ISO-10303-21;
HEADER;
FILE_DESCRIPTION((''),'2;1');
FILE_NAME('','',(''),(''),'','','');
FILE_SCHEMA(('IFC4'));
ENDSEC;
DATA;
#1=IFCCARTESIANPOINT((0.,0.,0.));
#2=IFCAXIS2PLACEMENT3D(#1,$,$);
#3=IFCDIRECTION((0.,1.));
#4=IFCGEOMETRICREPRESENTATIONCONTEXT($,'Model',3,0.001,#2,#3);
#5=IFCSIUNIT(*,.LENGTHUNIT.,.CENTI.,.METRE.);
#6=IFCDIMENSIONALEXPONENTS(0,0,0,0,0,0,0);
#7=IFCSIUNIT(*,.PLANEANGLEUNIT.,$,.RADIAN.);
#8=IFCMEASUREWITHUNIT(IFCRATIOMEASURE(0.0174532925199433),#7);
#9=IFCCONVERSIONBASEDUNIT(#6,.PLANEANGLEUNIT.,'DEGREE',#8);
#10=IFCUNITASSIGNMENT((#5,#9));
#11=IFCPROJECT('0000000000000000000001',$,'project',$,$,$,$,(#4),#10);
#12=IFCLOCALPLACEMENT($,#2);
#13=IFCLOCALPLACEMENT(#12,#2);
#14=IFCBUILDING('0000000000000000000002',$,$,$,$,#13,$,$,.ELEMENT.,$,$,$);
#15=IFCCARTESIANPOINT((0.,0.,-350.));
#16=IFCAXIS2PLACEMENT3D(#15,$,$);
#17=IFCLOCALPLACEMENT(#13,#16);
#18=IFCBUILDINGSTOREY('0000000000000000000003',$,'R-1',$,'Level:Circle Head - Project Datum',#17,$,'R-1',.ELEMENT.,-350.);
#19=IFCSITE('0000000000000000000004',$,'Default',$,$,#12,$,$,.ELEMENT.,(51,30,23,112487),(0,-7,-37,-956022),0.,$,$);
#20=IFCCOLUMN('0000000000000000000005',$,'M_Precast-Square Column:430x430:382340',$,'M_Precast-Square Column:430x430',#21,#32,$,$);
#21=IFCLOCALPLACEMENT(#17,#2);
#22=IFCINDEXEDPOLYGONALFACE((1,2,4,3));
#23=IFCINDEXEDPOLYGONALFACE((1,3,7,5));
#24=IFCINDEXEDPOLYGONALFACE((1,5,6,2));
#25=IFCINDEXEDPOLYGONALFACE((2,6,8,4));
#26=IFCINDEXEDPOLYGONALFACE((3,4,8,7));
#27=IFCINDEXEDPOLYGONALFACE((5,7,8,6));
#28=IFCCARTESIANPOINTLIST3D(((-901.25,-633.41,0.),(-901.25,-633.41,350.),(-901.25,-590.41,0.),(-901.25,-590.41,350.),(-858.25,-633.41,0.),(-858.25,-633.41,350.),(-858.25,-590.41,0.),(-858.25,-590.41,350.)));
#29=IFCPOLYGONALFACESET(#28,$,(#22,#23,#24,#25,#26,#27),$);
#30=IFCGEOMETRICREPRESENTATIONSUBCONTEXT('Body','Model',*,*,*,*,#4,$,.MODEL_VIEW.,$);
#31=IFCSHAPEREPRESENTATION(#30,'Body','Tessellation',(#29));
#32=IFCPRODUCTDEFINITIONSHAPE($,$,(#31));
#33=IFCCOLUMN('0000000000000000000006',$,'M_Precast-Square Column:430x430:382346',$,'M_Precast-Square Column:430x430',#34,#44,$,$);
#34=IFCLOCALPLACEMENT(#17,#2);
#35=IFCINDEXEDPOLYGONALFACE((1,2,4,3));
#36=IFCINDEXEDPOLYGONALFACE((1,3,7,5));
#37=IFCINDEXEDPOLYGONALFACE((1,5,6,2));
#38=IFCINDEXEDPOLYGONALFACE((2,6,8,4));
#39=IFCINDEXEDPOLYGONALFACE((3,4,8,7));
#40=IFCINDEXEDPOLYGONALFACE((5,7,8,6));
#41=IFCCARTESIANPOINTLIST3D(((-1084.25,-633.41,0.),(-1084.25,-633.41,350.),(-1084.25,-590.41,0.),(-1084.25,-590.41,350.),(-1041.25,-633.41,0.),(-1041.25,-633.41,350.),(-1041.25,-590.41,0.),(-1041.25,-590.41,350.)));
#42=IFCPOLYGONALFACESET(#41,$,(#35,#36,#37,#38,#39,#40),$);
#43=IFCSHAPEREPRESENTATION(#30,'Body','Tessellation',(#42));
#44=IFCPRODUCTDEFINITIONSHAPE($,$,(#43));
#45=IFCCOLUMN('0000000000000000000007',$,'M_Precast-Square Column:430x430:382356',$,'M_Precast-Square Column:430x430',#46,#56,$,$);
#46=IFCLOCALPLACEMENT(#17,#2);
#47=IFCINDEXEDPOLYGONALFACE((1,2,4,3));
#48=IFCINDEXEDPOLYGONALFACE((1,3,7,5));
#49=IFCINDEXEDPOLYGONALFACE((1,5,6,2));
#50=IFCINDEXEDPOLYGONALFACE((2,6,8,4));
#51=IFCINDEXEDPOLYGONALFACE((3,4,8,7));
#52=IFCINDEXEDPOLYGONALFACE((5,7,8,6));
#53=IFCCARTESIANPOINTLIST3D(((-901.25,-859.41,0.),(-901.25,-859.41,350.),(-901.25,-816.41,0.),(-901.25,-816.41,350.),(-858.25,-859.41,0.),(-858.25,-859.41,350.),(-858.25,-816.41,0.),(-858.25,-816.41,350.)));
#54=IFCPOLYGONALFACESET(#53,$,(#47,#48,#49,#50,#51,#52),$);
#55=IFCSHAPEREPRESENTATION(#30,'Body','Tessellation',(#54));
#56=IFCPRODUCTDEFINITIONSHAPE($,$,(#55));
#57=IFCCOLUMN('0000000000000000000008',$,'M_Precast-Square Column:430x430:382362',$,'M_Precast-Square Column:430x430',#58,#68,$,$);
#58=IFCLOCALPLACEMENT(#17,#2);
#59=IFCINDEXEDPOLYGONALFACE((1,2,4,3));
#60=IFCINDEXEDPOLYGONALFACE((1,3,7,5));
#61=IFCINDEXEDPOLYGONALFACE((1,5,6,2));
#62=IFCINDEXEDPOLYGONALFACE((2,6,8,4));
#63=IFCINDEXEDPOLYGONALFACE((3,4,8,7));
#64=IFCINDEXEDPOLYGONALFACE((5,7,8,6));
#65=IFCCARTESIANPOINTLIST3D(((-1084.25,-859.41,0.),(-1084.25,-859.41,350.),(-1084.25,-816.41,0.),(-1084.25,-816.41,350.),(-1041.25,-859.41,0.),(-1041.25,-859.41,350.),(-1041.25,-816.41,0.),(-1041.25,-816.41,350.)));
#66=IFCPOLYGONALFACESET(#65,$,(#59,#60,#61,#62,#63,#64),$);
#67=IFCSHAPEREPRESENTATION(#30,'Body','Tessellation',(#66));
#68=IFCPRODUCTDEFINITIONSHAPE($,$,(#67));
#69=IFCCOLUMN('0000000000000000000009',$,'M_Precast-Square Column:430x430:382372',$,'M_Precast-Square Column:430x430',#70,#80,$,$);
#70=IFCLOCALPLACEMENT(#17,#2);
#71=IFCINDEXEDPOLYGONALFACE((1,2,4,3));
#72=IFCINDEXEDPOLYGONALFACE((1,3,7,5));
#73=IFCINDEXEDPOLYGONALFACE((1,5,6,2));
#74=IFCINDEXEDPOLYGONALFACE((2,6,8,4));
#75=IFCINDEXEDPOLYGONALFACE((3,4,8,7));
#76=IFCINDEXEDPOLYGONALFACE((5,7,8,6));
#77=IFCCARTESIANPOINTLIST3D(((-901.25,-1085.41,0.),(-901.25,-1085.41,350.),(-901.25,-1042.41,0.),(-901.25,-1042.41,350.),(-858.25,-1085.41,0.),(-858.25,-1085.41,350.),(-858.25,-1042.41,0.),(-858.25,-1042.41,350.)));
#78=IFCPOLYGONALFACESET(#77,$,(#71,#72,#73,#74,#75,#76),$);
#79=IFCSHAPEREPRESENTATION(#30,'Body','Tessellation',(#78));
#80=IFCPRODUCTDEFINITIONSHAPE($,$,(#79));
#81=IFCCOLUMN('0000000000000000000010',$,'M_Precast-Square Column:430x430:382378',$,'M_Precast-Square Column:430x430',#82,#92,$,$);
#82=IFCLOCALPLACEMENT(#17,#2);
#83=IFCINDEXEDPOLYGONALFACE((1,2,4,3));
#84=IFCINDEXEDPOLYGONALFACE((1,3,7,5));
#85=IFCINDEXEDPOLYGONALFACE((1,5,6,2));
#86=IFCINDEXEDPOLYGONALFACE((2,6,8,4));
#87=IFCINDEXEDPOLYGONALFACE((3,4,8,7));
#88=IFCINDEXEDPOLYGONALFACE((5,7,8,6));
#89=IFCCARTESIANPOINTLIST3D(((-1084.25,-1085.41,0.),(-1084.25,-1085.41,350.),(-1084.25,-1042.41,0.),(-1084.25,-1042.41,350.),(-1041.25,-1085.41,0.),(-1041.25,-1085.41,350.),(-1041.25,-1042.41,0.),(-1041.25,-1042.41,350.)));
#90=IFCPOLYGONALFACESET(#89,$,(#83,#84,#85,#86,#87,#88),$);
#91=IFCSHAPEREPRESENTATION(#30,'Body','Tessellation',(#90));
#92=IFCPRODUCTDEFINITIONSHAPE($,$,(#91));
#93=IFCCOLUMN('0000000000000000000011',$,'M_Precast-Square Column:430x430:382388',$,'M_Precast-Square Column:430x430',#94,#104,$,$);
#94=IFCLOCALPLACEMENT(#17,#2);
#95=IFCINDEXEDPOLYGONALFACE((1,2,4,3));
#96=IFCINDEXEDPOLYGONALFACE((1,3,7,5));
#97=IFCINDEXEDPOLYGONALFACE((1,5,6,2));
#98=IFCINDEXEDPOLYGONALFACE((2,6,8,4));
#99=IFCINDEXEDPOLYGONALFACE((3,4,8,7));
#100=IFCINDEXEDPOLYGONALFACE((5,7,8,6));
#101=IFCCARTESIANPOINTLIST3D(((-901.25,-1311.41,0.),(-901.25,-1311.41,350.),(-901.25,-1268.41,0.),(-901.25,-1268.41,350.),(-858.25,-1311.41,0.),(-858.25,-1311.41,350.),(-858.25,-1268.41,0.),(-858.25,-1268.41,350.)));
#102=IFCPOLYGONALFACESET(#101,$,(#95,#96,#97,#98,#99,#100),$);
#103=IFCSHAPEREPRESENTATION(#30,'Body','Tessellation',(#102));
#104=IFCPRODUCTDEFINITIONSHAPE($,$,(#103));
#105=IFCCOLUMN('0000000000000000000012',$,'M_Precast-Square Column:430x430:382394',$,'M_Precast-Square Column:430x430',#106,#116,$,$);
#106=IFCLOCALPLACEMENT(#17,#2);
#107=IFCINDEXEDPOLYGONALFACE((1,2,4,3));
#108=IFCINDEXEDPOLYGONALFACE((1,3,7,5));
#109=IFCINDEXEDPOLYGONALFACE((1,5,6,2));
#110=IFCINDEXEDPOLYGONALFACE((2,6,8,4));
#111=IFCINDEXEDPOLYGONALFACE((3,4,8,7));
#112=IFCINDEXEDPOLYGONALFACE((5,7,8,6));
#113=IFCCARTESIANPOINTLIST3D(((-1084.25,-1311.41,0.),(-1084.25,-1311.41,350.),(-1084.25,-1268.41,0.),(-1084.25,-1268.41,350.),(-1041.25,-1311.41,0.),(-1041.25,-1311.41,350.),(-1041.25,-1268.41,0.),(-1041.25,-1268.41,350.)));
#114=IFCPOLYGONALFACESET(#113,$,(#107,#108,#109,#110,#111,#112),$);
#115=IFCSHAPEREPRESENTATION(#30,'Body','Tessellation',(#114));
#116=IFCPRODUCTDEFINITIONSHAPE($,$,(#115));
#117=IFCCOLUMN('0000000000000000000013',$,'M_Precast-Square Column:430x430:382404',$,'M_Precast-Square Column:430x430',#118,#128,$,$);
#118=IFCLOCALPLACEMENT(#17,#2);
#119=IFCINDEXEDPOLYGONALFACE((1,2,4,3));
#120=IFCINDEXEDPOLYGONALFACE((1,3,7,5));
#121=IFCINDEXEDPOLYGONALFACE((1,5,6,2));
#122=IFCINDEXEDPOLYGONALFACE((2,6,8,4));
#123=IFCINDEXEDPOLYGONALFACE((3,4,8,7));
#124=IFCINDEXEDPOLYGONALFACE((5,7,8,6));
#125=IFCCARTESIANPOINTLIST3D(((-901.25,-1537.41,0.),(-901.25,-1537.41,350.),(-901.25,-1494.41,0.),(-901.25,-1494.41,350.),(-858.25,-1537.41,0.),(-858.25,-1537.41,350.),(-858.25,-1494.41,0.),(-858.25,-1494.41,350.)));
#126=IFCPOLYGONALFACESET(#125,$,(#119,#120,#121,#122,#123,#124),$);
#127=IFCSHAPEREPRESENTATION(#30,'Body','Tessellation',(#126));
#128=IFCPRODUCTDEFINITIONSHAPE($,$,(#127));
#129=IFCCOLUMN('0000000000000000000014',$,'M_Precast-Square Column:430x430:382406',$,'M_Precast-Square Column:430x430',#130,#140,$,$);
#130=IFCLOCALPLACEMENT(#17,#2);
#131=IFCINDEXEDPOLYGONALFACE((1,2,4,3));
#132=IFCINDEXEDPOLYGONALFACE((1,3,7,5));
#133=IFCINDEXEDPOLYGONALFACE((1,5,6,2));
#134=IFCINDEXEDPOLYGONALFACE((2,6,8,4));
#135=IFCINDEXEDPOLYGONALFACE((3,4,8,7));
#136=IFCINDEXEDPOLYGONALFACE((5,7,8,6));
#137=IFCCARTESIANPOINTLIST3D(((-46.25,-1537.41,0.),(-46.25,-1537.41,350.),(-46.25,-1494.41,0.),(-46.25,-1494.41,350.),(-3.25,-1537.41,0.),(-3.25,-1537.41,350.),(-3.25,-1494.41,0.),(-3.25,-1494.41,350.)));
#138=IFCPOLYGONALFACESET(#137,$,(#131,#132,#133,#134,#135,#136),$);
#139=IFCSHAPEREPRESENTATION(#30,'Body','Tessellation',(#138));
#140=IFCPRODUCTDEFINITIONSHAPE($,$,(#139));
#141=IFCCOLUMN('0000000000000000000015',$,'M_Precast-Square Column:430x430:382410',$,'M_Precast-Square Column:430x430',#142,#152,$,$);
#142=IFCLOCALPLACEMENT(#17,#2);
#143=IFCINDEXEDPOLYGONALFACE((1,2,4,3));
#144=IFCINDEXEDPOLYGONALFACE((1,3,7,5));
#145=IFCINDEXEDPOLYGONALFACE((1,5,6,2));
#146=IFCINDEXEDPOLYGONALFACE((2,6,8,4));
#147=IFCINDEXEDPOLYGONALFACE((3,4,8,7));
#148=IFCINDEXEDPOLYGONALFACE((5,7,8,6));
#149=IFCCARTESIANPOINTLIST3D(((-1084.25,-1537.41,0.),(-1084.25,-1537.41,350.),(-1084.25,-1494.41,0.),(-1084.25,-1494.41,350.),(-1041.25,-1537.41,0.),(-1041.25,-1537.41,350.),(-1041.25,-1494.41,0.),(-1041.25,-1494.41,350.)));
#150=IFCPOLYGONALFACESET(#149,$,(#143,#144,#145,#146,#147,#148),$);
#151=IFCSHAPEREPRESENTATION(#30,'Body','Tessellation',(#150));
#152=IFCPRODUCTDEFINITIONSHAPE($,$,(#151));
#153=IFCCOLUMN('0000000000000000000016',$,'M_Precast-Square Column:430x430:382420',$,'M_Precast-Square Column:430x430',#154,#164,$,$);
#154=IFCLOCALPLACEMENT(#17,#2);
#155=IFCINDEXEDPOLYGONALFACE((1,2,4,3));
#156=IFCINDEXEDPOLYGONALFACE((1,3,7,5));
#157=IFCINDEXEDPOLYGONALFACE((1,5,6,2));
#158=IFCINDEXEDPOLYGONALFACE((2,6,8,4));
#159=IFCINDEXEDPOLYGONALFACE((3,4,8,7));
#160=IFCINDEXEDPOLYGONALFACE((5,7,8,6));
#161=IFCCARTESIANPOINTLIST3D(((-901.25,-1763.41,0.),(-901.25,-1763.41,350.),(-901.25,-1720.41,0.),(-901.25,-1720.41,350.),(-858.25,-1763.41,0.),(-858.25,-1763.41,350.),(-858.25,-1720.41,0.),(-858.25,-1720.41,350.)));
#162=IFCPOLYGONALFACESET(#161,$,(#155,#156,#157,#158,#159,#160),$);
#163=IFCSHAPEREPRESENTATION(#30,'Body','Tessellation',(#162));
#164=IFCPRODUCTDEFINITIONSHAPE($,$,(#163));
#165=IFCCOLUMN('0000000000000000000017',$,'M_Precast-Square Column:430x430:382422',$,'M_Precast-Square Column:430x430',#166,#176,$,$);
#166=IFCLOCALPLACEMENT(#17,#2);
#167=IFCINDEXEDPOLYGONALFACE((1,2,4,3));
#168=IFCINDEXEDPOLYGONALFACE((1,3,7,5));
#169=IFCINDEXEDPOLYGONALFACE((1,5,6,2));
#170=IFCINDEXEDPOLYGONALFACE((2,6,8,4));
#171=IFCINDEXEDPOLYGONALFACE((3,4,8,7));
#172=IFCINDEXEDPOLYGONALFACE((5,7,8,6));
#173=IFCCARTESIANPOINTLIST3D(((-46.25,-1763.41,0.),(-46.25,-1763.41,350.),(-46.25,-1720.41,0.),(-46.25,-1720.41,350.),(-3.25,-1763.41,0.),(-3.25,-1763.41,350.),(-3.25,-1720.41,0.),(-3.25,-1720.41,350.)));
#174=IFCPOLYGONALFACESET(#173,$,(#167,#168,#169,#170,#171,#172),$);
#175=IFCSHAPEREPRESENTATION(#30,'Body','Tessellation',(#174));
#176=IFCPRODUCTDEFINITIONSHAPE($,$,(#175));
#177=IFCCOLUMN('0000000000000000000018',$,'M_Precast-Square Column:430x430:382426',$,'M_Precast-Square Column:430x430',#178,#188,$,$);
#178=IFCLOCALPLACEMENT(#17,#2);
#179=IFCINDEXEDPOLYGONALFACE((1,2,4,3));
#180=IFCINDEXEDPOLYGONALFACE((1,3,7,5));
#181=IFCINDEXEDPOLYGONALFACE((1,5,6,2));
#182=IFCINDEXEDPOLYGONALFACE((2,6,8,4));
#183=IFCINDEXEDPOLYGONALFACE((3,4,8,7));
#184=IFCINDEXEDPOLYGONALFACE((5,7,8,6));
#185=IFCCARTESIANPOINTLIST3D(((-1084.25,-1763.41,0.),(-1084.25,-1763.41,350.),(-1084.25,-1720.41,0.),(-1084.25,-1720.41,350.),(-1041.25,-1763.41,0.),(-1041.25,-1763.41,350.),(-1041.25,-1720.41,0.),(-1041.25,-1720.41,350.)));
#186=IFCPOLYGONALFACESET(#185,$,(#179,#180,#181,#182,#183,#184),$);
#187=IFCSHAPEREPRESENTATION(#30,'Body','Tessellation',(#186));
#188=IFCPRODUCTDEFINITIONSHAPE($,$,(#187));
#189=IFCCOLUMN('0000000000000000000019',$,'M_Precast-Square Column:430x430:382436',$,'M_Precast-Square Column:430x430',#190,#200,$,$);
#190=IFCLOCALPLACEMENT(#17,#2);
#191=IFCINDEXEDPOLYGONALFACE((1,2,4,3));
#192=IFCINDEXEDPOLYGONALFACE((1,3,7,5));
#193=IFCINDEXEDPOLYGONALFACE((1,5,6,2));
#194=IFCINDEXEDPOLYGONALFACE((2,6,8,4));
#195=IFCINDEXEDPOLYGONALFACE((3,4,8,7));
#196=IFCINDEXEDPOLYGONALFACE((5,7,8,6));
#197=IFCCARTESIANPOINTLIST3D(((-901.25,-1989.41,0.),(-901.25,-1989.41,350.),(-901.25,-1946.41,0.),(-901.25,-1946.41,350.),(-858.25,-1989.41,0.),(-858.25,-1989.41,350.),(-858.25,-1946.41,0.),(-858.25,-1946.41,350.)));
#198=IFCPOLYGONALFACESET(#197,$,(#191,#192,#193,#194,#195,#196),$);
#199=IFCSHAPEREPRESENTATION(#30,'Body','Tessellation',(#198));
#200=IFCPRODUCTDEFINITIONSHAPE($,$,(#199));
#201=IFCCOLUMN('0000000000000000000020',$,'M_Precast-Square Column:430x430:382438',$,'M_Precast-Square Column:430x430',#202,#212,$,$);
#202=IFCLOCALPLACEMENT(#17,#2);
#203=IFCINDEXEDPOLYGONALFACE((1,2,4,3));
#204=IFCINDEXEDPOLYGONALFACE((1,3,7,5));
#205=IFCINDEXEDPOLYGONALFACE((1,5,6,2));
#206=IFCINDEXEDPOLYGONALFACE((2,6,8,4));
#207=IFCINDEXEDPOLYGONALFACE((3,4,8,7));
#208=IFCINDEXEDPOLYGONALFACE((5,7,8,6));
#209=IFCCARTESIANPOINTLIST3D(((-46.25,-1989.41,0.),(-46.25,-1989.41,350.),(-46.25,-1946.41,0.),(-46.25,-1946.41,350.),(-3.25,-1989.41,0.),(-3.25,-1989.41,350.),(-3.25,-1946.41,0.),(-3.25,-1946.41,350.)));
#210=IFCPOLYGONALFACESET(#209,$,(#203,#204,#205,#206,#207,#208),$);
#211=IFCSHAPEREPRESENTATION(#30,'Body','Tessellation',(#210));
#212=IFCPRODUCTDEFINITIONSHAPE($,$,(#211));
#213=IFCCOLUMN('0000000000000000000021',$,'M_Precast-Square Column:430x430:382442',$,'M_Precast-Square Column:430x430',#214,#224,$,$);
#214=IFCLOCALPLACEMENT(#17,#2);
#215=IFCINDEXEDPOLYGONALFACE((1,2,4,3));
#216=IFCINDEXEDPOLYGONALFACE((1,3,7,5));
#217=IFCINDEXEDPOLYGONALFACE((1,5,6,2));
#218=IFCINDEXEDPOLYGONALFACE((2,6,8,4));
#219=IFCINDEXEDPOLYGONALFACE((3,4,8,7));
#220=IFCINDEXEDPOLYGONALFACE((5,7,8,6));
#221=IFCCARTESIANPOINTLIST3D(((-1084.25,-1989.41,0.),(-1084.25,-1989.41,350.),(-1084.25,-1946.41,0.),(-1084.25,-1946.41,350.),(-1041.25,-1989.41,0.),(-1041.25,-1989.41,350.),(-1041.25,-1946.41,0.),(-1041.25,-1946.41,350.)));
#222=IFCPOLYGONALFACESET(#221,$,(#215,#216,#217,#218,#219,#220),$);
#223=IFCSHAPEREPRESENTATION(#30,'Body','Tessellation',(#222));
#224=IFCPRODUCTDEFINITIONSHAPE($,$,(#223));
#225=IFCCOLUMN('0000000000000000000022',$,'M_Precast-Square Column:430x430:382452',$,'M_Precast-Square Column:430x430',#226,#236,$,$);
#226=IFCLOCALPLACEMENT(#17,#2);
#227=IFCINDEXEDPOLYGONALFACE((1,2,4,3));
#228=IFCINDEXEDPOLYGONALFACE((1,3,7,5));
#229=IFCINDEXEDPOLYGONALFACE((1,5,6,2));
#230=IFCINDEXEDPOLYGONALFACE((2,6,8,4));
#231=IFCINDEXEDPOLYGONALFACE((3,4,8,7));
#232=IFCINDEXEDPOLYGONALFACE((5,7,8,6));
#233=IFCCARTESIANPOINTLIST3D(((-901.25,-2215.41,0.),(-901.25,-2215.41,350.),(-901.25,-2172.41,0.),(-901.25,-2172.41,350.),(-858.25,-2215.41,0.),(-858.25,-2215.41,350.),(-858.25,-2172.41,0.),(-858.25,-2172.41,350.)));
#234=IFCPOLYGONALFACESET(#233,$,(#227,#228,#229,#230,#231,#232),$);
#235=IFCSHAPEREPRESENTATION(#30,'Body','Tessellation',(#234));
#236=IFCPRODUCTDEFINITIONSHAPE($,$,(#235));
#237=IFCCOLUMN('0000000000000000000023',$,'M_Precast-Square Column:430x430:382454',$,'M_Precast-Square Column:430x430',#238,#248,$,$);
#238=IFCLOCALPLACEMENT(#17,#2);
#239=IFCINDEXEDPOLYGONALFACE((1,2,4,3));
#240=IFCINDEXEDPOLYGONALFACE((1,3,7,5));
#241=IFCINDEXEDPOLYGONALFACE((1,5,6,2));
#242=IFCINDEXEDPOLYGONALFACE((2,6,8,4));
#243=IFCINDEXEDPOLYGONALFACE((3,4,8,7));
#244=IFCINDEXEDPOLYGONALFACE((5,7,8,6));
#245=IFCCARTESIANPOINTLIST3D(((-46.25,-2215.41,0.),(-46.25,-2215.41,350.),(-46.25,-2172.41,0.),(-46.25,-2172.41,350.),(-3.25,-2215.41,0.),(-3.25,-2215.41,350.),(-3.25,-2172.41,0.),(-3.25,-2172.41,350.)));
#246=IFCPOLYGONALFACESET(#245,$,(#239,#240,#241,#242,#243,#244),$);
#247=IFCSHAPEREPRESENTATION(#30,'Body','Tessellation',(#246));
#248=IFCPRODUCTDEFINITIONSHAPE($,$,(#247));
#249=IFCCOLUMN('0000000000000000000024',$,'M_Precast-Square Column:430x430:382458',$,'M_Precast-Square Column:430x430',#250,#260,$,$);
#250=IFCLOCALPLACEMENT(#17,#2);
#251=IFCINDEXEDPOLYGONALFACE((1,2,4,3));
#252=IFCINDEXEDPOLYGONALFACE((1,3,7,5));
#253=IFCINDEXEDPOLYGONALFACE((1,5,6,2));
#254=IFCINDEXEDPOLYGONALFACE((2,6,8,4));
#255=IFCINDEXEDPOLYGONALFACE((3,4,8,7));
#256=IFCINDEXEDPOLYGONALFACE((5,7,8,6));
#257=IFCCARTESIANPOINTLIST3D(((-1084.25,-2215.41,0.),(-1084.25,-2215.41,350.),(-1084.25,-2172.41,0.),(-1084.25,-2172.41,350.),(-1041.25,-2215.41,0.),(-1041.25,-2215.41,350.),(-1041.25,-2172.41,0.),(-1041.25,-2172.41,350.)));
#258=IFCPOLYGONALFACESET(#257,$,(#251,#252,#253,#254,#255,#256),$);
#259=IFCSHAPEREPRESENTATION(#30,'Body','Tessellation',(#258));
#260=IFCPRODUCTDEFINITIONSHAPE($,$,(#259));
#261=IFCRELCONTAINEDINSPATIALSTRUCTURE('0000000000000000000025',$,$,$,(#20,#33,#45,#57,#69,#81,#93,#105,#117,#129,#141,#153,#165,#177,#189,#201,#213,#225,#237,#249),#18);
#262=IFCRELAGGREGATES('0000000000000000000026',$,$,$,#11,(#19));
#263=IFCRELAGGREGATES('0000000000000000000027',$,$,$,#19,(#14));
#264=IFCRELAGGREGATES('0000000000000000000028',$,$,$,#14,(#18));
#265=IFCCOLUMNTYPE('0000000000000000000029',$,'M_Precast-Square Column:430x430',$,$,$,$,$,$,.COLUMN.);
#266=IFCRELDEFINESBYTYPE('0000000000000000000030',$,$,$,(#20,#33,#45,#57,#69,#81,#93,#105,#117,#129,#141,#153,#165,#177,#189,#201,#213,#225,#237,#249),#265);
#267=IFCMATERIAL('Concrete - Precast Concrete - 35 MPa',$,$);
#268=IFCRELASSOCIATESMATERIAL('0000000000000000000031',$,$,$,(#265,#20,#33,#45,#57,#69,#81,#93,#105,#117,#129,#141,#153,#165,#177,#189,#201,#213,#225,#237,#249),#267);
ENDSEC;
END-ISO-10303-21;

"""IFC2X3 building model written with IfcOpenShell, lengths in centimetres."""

from ifc_helpers import new_model, entity, si_unit, converted_unit, direction, frame, origin, origin_2d_with_axis, place, context, subcontext, project, spatial, rectangle, extrude, source, transform, mapped, material, type_object, type_shapes, element, save


model = new_model("IFC2X3")

# Units and contexts
model_context = context("Model", 3, precision=0.001, world=origin(), true_north=direction((0.0, 1.0)))
body_context = subcontext(model_context, "Body", "Model", "MODEL_VIEW")
ifc_project = project(units=[si_unit("LENGTHUNIT", "METRE", prefix="CENTI"), converted_unit("PLANEANGLEUNIT", "DEGREE", entity("IfcRatioMeasure", 0.0174532925199433), si_unit("PLANEANGLEUNIT", "RADIAN"), dimensions=[0, 0, 0, 0, 0, 0, 0])], contexts=[model_context])

# Site, building, storey
site_placement = place(None, origin())
site = spatial("IfcSite", under=ifc_project, at=site_placement, Name="Default", CompositionType="ELEMENT", RefLatitude=(51, 30, 23, 112487), RefLongitude=(0, -7, -37, -956022), RefElevation=0.0)
building_placement = place(site_placement, origin())
building = spatial("IfcBuilding", under=site, at=building_placement, CompositionType="ELEMENT")
storey_placement = place(building_placement, frame((0.0, 0.0, -350.0)))
storey = spatial("IfcBuildingStorey", under=building, at=storey_placement, Name="R-1", ObjectType="Level:Circle Head - Project Datum", LongName="R-1", CompositionType="ELEMENT", Elevation=-350.0)

# Columns
ifc_material_1 = material(Name="Concrete - Precast Concrete - 35 MPa")
column_type = type_object("IfcColumnType", Name="M_Precast-Square Column:430x430", PredefinedType="COLUMN", material=ifc_material_1)
shared_shape = source(origin(), body_context, "Body", "SweptSolid", [
    extrude(rectangle(XDim=43.0, YDim=43.0, at=origin_2d_with_axis()), frame((0.0, 0.0, -350.0), z_axis=(0.0, 0.0, 1.0), x_axis=(0.0, -1.0, 0.0)), (0.0, 0.0, 1.0), 350.0),
])
type_shapes(column_type, [shared_shape])
for number, where, z_axis, x_axis, name in (
    (1, (-879.75, -611.91, 350.0), (0.0, 0.0, 1.0), (-1.0, 0.0, 0.0), "M_Precast-Square Column:430x430:382340"),
    (2, (-1062.75, -611.91, 350.0), (0.0, 0.0, 1.0), (-1.0, 0.0, 0.0), "M_Precast-Square Column:430x430:382346"),
    (3, (-879.75, -837.91, 350.0), (0.0, 0.0, 1.0), (-1.0, 0.0, 0.0), "M_Precast-Square Column:430x430:382356"),
    (4, (-1062.75, -837.91, 350.0), (0.0, 0.0, 1.0), (-1.0, 0.0, 0.0), "M_Precast-Square Column:430x430:382362"),
    (5, (-879.75, -1063.91, 350.0), (0.0, 0.0, 1.0), (-1.0, 0.0, 0.0), "M_Precast-Square Column:430x430:382372"),
    (6, (-1062.75, -1063.91, 350.0), (0.0, 0.0, 1.0), (-1.0, 0.0, 0.0), "M_Precast-Square Column:430x430:382378"),
    (7, (-879.75, -1289.91, 350.0), (0.0, 0.0, 1.0), (-1.0, 0.0, 0.0), "M_Precast-Square Column:430x430:382388"),
    (8, (-1062.75, -1289.91, 350.0), (0.0, 0.0, 1.0), (-1.0, 0.0, 0.0), "M_Precast-Square Column:430x430:382394"),
    (9, (-879.75, -1515.91, 350.0), (0.0, 0.0, 1.0), (-1.0, 0.0, 0.0), "M_Precast-Square Column:430x430:382404"),
    (10, (-24.75, -1515.91, 350.0), (0.0, 0.0, 1.0), (-1.0, 0.0, 0.0), "M_Precast-Square Column:430x430:382406"),
    (11, (-1062.75, -1515.91, 350.0), (0.0, 0.0, 1.0), (-1.0, 0.0, 0.0), "M_Precast-Square Column:430x430:382410"),
    (12, (-879.75, -1741.91, 350.0), (0.0, 0.0, 1.0), (-1.0, 0.0, 0.0), "M_Precast-Square Column:430x430:382420"),
    (13, (-24.75, -1741.91, 350.0), (0.0, 0.0, 1.0), (-1.0, 0.0, 0.0), "M_Precast-Square Column:430x430:382422"),
    (14, (-1062.75, -1741.91, 350.0), (0.0, 0.0, 1.0), (-1.0, 0.0, 0.0), "M_Precast-Square Column:430x430:382426"),
    (15, (-879.75, -1967.91, 350.0), (0.0, 0.0, 1.0), (-1.0, 0.0, 0.0), "M_Precast-Square Column:430x430:382436"),
    (16, (-24.75, -1967.91, 350.0), (0.0, 0.0, 1.0), (-1.0, 0.0, 0.0), "M_Precast-Square Column:430x430:382438"),
    (17, (-1062.75, -1967.91, 350.0), (0.0, 0.0, 1.0), (-1.0, 0.0, 0.0), "M_Precast-Square Column:430x430:382442"),
    (18, (-879.75, -2193.91, 350.0), (0.0, 0.0, 1.0), (-1.0, 0.0, 0.0), "M_Precast-Square Column:430x430:382452"),
    (19, (-24.75, -2193.91, 350.0), (0.0, 0.0, 1.0), (-1.0, 0.0, 0.0), "M_Precast-Square Column:430x430:382454"),
    (20, (-1062.75, -2193.91, 350.0), (0.0, 0.0, 1.0), (-1.0, 0.0, 0.0), "M_Precast-Square Column:430x430:382458"),
):
    element("IfcColumn", number, at=place(storey_placement, frame(where, z_axis=z_axis, x_axis=x_axis)), inside=storey, type_object=column_type, material=ifc_material_1, Name=name, ObjectType="M_Precast-Square Column:430x430", context=body_context, shape_type="MappedRepresentation", body=[
        mapped(shared_shape, transform((0.0, 0.0, 0.0), scale=1.0)),
    ])

save(model, "model.ifc")
